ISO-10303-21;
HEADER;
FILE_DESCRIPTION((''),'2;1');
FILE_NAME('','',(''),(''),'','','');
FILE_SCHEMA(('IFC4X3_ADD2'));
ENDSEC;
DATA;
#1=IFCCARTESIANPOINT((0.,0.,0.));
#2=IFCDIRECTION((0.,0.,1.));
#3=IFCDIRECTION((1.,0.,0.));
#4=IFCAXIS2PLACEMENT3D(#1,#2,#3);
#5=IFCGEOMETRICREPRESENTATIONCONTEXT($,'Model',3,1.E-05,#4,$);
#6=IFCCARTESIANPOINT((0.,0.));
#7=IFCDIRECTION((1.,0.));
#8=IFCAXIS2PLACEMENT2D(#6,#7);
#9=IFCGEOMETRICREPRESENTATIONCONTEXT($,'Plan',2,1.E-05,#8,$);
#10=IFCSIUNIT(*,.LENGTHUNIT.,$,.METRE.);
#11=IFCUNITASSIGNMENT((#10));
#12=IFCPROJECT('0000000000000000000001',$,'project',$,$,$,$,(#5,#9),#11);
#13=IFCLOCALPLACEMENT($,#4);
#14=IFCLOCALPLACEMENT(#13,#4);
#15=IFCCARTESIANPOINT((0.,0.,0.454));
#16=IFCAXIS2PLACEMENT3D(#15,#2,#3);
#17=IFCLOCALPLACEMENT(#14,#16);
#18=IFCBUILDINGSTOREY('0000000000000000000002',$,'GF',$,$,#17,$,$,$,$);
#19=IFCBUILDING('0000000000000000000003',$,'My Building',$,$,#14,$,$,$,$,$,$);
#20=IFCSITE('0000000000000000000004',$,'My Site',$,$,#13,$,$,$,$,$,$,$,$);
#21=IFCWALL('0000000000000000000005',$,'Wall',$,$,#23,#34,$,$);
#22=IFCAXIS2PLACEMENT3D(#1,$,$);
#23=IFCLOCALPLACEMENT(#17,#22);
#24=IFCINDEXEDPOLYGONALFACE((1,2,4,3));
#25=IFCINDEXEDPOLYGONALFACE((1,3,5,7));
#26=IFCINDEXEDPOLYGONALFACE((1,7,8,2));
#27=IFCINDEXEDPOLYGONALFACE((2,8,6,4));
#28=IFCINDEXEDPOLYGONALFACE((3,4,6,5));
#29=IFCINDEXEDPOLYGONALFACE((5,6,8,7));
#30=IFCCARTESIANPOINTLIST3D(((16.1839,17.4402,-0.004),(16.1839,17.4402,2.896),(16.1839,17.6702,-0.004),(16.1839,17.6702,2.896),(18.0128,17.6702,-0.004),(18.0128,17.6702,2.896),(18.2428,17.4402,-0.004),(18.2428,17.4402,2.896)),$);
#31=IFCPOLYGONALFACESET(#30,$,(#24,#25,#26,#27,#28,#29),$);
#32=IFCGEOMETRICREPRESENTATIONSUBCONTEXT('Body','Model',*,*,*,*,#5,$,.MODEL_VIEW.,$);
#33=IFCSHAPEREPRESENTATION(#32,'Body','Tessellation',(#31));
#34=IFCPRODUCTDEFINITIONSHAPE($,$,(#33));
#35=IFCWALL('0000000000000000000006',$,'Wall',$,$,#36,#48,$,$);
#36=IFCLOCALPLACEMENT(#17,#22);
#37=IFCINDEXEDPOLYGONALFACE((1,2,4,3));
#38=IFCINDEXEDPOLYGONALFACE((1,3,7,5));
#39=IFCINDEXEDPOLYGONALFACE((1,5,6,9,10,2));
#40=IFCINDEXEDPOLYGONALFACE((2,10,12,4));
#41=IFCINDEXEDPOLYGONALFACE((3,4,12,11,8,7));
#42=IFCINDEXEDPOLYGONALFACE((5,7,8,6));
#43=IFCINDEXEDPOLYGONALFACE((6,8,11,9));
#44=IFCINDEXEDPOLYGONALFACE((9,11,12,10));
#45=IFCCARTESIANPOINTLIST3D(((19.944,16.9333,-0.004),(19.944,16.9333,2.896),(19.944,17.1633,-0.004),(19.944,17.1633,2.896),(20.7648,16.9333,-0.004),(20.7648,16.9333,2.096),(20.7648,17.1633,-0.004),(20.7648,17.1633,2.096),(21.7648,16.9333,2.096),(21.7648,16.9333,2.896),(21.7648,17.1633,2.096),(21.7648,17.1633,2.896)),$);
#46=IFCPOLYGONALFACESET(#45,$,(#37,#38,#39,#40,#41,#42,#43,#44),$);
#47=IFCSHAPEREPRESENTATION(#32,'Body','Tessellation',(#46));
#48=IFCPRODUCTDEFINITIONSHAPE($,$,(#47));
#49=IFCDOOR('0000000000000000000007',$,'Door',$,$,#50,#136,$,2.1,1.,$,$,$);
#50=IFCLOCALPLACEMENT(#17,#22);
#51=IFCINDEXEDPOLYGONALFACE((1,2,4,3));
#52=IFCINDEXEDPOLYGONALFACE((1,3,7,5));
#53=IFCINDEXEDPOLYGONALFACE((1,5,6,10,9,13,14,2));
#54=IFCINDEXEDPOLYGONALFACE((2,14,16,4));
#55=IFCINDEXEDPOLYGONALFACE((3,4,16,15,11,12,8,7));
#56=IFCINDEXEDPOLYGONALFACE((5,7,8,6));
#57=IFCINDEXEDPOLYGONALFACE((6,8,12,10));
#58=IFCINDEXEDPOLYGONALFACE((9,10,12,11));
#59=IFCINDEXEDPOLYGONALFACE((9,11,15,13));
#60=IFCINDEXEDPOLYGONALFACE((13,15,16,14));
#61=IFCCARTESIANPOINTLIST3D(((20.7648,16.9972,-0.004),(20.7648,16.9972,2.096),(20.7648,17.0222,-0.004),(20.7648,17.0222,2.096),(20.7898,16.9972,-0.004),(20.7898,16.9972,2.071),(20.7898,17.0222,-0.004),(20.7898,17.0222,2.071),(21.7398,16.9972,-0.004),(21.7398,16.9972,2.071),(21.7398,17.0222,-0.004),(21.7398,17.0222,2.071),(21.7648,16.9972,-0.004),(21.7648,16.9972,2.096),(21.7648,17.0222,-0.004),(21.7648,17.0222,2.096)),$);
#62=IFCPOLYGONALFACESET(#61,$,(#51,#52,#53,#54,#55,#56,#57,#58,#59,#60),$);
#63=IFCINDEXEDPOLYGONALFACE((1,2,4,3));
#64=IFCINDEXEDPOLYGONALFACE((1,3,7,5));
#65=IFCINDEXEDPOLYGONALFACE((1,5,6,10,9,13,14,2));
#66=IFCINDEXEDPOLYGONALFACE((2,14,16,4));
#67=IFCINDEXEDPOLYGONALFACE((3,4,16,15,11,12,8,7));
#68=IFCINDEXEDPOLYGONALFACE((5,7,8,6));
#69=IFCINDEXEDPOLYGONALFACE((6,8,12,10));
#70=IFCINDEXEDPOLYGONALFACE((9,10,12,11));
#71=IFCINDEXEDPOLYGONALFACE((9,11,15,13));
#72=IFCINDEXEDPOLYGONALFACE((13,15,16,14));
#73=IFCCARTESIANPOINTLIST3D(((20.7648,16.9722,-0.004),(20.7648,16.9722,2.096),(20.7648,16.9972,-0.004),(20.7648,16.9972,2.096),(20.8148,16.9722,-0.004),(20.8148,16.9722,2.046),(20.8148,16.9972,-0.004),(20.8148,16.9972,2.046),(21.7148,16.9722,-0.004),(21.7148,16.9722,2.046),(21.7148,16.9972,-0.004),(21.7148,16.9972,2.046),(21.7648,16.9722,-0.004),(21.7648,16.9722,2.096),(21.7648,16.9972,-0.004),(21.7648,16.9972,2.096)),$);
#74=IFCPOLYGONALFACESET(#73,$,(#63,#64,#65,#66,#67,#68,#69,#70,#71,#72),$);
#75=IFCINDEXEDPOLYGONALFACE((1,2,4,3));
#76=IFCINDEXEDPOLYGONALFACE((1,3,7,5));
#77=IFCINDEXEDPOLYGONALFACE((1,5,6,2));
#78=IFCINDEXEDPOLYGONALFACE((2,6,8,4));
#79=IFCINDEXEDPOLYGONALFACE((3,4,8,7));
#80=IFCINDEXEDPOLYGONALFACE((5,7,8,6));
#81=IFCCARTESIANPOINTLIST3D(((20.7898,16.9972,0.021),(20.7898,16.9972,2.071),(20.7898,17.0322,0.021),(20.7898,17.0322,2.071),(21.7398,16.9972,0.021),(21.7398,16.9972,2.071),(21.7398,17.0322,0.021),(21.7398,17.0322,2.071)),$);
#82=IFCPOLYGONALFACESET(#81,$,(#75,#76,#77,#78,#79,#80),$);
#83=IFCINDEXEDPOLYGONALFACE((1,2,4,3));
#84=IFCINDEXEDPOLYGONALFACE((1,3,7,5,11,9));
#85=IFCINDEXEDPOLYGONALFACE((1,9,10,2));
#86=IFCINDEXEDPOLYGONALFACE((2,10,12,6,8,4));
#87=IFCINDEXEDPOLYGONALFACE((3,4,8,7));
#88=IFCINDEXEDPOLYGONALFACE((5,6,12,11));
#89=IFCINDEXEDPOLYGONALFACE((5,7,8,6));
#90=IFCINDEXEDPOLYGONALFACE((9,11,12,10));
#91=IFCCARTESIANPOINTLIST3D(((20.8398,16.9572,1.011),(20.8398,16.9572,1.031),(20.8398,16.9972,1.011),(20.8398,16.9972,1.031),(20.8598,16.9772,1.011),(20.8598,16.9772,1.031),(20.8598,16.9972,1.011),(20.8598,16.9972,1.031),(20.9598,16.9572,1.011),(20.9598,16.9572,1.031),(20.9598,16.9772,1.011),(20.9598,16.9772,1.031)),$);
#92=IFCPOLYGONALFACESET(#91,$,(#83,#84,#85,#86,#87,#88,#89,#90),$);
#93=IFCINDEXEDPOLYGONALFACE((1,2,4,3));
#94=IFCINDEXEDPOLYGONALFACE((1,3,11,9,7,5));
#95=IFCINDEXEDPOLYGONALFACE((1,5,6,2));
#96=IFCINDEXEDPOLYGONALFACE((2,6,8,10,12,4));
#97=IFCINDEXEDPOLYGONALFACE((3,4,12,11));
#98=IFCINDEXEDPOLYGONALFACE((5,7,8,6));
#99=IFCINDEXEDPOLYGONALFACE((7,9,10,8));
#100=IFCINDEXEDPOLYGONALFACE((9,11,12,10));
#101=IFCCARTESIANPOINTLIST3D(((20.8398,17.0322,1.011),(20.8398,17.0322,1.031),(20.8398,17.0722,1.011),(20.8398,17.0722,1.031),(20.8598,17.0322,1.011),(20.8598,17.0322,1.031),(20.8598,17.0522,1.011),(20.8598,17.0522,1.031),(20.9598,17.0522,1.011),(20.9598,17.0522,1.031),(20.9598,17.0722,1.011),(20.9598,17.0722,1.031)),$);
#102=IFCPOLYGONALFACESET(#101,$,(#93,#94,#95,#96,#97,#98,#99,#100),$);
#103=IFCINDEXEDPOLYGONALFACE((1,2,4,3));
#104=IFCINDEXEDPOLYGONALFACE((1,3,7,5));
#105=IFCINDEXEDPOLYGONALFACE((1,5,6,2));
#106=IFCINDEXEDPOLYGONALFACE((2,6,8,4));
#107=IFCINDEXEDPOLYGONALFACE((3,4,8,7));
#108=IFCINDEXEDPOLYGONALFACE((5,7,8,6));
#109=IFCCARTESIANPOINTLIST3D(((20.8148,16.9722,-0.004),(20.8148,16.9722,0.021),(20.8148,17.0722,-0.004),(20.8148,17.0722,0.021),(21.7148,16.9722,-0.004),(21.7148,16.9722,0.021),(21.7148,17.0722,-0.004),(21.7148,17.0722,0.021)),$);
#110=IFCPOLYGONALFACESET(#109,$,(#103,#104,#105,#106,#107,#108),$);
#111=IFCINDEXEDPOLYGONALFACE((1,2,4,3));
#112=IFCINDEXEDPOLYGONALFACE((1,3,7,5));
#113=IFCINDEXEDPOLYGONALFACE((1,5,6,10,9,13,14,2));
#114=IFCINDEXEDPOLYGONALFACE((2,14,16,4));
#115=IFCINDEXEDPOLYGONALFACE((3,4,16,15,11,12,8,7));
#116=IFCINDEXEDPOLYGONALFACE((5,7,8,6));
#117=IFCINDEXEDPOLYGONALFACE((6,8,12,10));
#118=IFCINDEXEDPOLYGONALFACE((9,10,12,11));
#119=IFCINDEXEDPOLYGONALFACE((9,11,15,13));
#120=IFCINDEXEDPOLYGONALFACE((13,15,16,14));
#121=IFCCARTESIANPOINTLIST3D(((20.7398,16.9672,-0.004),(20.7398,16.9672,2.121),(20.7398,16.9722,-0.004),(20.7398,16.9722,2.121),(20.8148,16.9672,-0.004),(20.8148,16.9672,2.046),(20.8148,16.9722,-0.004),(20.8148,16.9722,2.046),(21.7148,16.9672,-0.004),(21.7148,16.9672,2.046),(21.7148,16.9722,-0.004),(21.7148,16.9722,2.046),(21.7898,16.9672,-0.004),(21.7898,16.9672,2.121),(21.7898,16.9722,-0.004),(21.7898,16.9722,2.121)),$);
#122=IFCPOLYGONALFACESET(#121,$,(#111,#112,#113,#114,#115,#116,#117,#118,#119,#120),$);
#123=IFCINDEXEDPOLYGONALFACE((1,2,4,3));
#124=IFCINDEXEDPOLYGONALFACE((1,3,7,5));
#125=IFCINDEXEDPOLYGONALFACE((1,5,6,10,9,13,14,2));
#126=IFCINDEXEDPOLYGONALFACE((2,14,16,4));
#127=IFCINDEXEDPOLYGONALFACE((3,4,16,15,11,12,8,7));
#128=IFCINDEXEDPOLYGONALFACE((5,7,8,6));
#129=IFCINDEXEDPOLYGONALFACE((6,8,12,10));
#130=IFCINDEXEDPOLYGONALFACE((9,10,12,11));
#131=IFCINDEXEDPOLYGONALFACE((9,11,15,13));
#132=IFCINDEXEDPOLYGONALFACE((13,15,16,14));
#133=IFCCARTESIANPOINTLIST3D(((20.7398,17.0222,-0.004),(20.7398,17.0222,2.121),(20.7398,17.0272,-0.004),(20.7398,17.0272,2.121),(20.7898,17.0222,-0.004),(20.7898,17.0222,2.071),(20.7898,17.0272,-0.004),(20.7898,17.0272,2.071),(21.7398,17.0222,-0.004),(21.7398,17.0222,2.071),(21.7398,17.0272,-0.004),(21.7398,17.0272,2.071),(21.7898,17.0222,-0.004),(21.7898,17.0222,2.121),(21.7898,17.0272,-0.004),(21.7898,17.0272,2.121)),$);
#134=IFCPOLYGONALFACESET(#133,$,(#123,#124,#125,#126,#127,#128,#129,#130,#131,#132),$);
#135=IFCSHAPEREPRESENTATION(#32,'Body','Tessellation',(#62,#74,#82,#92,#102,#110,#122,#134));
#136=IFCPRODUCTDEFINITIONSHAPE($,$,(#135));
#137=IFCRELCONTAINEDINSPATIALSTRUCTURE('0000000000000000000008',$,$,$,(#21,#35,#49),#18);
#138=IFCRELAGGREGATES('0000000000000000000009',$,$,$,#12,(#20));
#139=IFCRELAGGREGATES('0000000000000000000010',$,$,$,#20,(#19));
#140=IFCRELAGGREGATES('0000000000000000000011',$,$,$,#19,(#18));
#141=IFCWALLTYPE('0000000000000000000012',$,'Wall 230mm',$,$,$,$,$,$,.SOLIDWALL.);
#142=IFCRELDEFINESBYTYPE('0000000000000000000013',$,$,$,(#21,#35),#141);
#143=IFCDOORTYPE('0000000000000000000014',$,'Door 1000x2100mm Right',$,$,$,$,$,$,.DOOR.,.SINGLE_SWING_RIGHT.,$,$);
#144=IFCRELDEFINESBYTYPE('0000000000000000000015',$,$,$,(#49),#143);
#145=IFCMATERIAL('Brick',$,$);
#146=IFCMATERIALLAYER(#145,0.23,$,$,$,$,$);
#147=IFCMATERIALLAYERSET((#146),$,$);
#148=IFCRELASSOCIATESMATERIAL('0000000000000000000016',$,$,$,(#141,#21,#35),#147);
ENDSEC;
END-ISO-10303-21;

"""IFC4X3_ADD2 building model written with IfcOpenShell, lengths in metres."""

from ifc_helpers import new_model, entity, si_unit, frame, origin_with_axes, origin_2d_with_axis, place, context, subcontext, project, spatial, line, indexed_curve, outline, extrude, clip, halfspace, shape, source, transform, mapped, material, layer, layer_set, layer_usage, type_object, type_shapes, element, fill, save


model = new_model("IFC4X3_ADD2")

# Units and contexts
model_context = context("Model", 3, precision=1e-05, world=origin_with_axes())
plan_context = context("Plan", 2, precision=1e-05, world=origin_2d_with_axis())
body_context_1 = subcontext(model_context, "Body", "Model", "MODEL_VIEW")
body_context_2 = subcontext(plan_context, "Body", "Plan", "PLAN_VIEW")
ifc_project = project(units=[si_unit("LENGTHUNIT", "METRE")], contexts=[model_context, plan_context])

# Site, building, storey
site_placement = place(None, origin_with_axes())
site = spatial("IfcSite", under=ifc_project, at=site_placement, Name="My Site")
building_placement = place(site_placement, origin_with_axes())
building = spatial("IfcBuilding", under=site, at=building_placement, Name="My Building")
storey_placement = place(building_placement, frame((0.0, 0.0, 0.454), z_axis=(0.0, 0.0, 1.0), x_axis=(1.0, 0.0, 0.0)))
storey = spatial("IfcBuildingStorey", under=building, at=storey_placement, Name="GF")

# Shared definitions
ifc_material_1 = material(Name="Brick")

# Shared definitions
ifc_layer_1 = layer(ifc_material_1, 0.23)
ifc_layer_set_1 = layer_set([ifc_layer_1])
wall_type_1 = type_object("IfcWallType", Name="Wall 230mm", PredefinedType="SOLIDWALL", material=ifc_layer_set_1)

# Wall
ifc_layer_usage_1 = layer_usage(ifc_layer_set_1, "AXIS2", "POSITIVE", 0.0)
wall_1_placement = place(storey_placement, frame((18.2428, 17.6702, -0.004), z_axis=(0.0, 0.0, 1.0), x_axis=(-1.0, 0.0, 0.0)))
element("IfcWall", 1, at=wall_1_placement, inside=storey, type_object=wall_type_1, material=ifc_layer_usage_1, Name="Wall", context=body_context_1, shape_type="Clipping", body=[
    clip(extrude(outline(indexed_curve([(0.0, 0.0), (0.0, 0.23), (2.0589, 0.23), (2.0589, 0.0), (0.0, 0.0)], self_intersect=False)), origin_with_axes(), (0.0, 0.0, 1.0), 2.9), halfspace(frame((0.23, 0.0, -0.454), z_axis=(-0.689999, -0.689999, 0.0), x_axis=(-0.707107, 0.707107, 0.0)), False)),
])

# Wall, opening, door
ifc_layer_usage_2 = layer_usage(ifc_layer_set_1, "AXIS2", "POSITIVE", 0.0)
wall_2_placement = place(storey_placement, frame((21.7648, 17.1633, -0.004), z_axis=(0.0, 0.0, 1.0), x_axis=(-1.0, 0.0, 0.0)))
wall_2 = element("IfcWall", 2, at=wall_2_placement, inside=storey, type_object=wall_type_1, material=ifc_layer_usage_2, Name="Wall", context=body_context_1, shape_type="SweptSolid", body=[
    extrude(outline(indexed_curve([(0.0, 0.0), (0.0, 0.23), (1.8208, 0.23), (1.8208, 0.0), (0.0, 0.0)], self_intersect=False)), origin_with_axes(), (0.0, 0.0, 1.0), 2.9),
])
shared_shape_1 = source(origin_with_axes(), body_context_1, "Body", "SweptSolid", [
    extrude(outline(indexed_curve([(0.0, 0.0), (1.0, 0.0), (1.0, 2.1), (0.0, 2.1)], segments=[line(1, 2, 3, 4, 1)])), frame((0.0, -0.6, 0.0), z_axis=(0.0, -1.0, 0.0), x_axis=(1.0, 0.0, 0.0)), (0.0, 0.0, -1.0), 1.2),
])
opening_1_placement = place(wall_2_placement, frame((1.0, 0.1911, 0.0), z_axis=(0.0, 0.0, 1.0), x_axis=(-1.0, 0.0, 0.0)))
opening_1 = element("IfcOpeningElement", 3, at=opening_1_placement, cuts=wall_2, PredefinedType="OPENING", context=body_context_1, shape_type="MappedRepresentation", body=[
    mapped(shared_shape_1, transform((0.0, 0.0, 0.0), x_axis=(1.0, 0.0, 0.0), y_axis=(0.0, 1.0, 0.0), z_axis=(0.0, 0.0, 1.0), scale=1.0)),
])
door_type_1 = type_object("IfcDoorType", Name="Door 1000x2100mm Right", OperationType="SINGLE_SWING_RIGHT", PredefinedType="DOOR")
shared_shape_2 = source(origin_with_axes(), body_context_1, "Body", "SweptSolid", [
    extrude(outline(indexed_curve([(0.0, 0.0), (0.0, 2.1), (1.0, 2.1), (1.0, 0.0), (0.975, 0.0), (0.975, 2.075), (0.025, 2.075), (0.025, 0.0)], segments=[line(1, 2, 3, 4, 5, 6, 7, 8, 1)])), frame((0.0, 0.025, 0.0), z_axis=(0.0, -1.0, 0.0), x_axis=(1.0, 0.0, 0.0)), (0.0, 0.0, -1.0), 0.025),
    extrude(outline(indexed_curve([(0.0, 0.0), (0.0, 2.1), (1.0, 2.1), (1.0, 0.0), (0.95, 0.0), (0.95, 2.05), (0.05, 2.05), (0.05, 0.0)], segments=[line(1, 2, 3, 4, 5, 6, 7, 8, 1)])), frame((0.0, 0.0, 0.0), z_axis=(0.0, -1.0, 0.0), x_axis=(1.0, 0.0, 0.0)), (0.0, 0.0, -1.0), 0.025),
    extrude(outline(indexed_curve([(0.0, 0.0), (0.95, 0.0), (0.95, 0.035), (0.0, 0.035)], segments=[line(1, 2, 3, 4, 1)])), frame((0.025, 0.025, 0.025), z_axis=(0.0, 0.0, 1.0), x_axis=(1.0, 0.0, 0.0)), (0.0, 0.0, 1.0), 2.05),
    extrude(outline(indexed_curve([(0.0, 0.0), (0.0, -0.04), (0.12, -0.04), (0.12, -0.02), (0.02, -0.02), (0.02, 0.0)], segments=[line(1, 2, 3, 4, 5, 6, 1)])), frame((0.075, 0.025, 1.015), z_axis=(0.0, 0.0, 1.0), x_axis=(1.0, 0.0, 0.0)), (0.0, 0.0, 1.0), 0.02),
    extrude(outline(indexed_curve([(0.0, 0.0), (0.0, 0.04), (0.12, 0.04), (0.12, 0.02), (0.02, 0.02), (0.02, 0.0)], segments=[line(1, 2, 3, 4, 5, 6, 1)])), frame((0.075, 0.06, 1.015), z_axis=(0.0, 0.0, 1.0), x_axis=(1.0, 0.0, 0.0)), (0.0, 0.0, 1.0), 0.02),
    extrude(outline(indexed_curve([(0.0, 0.0), (0.9, 0.0), (0.9, 0.1), (0.0, 0.1)], segments=[line(1, 2, 3, 4, 1)])), frame((0.05, 0.0, 0.0), z_axis=(0.0, 0.0, 1.0), x_axis=(1.0, 0.0, 0.0)), (0.0, 0.0, 1.0), 0.025),
    extrude(outline(indexed_curve([(0.0, 0.0), (0.0, 2.125), (1.05, 2.125), (1.05, 0.0), (0.975, 0.0), (0.975, 2.05), (0.075, 2.05), (0.075, 0.0)], segments=[line(1, 2, 3, 4, 5, 6, 7, 8, 1)])), frame((-0.025, -0.005, 0.0), z_axis=(0.0, -1.0, 0.0), x_axis=(1.0, 0.0, 0.0)), (0.0, 0.0, -1.0), 0.005),
    extrude(outline(indexed_curve([(0.0, 0.0), (0.0, 2.125), (1.05, 2.125), (1.05, 0.0), (1.0, 0.0), (1.0, 2.075), (0.05, 2.075), (0.05, 0.0)], segments=[line(1, 2, 3, 4, 5, 6, 7, 8, 1)])), frame((-0.025, 0.05, 0.0), z_axis=(0.0, -1.0, 0.0), x_axis=(1.0, 0.0, 0.0)), (0.0, 0.0, -1.0), 0.005),
])
shared_shape_3 = source(origin_with_axes(), body_context_2, "Body", "Curve2D", [
    entity("IfcIndexedPolyCurve", entity("IfcCartesianPointList2D", [[0.0, 0.0], [0.0, 0.05], [0.025, 0.05], [0.025, 0.025], [0.05, 0.025], [0.05, 0.0]]), [entity("IfcLineIndex", [1, 2, 3, 4, 5, 6, 1])]),
    entity("IfcIndexedPolyCurve", entity("IfcCartesianPointList2D", [[1.0, 0.0], [1.0, 0.05], [0.975, 0.05], [0.975, 0.025], [0.95, 0.025], [0.95, 0.0]]), [entity("IfcLineIndex", [1, 2, 3, 4, 5, 6, 1])]),
    entity("IfcTrimmedCurve", entity("IfcEllipse", entity("IfcAxis2Placement2D", entity("IfcCartesianPoint", [0.94, 0.05]), entity("IfcDirection", [1.0, 0.0])), 0.915, 0.95), [entity("IfcCartesianPoint", [0.94, 1.0])], [entity("IfcCartesianPoint", [0.025, 0.05])], True, "CARTESIAN"),
    entity("IfcIndexedPolyCurve", entity("IfcCartesianPointList2D", [[0.975, 0.05], [0.94, 0.05], [0.94, 1.0], [0.975, 1.0]]), [entity("IfcLineIndex", [1, 2, 3, 4, 1])]),
])
type_shapes(door_type_1, [shared_shape_2, shared_shape_3])
door_1_placement = place(opening_1_placement, frame((0.0, 0.0, 0.0), z_axis=(0.0, 0.0, 1.0), x_axis=(1.0, 0.0, 0.0)))
door_1 = element("IfcDoor", 4, at=door_1_placement, inside=storey, type_object=door_type_1, Name="Door", OverallHeight=2.1, OverallWidth=1.0, shapes=[
    shape(body_context_1, "Body", "MappedRepresentation", [mapped(shared_shape_2, transform((0.0, 0.0, 0.0), x_axis=(1.0, 0.0, 0.0), y_axis=(0.0, 1.0, 0.0), z_axis=(0.0, 0.0, 1.0), scale=1.0))]),
    shape(body_context_2, "Body", "MappedRepresentation", [mapped(shared_shape_3, transform((0.0, 0.0, 0.0), x_axis=(1.0, 0.0, 0.0), y_axis=(0.0, 1.0, 0.0), z_axis=(0.0, 0.0, 1.0), scale=1.0))]),
])
fill(opening_1, door_1)

save(model, "model.ifc")
